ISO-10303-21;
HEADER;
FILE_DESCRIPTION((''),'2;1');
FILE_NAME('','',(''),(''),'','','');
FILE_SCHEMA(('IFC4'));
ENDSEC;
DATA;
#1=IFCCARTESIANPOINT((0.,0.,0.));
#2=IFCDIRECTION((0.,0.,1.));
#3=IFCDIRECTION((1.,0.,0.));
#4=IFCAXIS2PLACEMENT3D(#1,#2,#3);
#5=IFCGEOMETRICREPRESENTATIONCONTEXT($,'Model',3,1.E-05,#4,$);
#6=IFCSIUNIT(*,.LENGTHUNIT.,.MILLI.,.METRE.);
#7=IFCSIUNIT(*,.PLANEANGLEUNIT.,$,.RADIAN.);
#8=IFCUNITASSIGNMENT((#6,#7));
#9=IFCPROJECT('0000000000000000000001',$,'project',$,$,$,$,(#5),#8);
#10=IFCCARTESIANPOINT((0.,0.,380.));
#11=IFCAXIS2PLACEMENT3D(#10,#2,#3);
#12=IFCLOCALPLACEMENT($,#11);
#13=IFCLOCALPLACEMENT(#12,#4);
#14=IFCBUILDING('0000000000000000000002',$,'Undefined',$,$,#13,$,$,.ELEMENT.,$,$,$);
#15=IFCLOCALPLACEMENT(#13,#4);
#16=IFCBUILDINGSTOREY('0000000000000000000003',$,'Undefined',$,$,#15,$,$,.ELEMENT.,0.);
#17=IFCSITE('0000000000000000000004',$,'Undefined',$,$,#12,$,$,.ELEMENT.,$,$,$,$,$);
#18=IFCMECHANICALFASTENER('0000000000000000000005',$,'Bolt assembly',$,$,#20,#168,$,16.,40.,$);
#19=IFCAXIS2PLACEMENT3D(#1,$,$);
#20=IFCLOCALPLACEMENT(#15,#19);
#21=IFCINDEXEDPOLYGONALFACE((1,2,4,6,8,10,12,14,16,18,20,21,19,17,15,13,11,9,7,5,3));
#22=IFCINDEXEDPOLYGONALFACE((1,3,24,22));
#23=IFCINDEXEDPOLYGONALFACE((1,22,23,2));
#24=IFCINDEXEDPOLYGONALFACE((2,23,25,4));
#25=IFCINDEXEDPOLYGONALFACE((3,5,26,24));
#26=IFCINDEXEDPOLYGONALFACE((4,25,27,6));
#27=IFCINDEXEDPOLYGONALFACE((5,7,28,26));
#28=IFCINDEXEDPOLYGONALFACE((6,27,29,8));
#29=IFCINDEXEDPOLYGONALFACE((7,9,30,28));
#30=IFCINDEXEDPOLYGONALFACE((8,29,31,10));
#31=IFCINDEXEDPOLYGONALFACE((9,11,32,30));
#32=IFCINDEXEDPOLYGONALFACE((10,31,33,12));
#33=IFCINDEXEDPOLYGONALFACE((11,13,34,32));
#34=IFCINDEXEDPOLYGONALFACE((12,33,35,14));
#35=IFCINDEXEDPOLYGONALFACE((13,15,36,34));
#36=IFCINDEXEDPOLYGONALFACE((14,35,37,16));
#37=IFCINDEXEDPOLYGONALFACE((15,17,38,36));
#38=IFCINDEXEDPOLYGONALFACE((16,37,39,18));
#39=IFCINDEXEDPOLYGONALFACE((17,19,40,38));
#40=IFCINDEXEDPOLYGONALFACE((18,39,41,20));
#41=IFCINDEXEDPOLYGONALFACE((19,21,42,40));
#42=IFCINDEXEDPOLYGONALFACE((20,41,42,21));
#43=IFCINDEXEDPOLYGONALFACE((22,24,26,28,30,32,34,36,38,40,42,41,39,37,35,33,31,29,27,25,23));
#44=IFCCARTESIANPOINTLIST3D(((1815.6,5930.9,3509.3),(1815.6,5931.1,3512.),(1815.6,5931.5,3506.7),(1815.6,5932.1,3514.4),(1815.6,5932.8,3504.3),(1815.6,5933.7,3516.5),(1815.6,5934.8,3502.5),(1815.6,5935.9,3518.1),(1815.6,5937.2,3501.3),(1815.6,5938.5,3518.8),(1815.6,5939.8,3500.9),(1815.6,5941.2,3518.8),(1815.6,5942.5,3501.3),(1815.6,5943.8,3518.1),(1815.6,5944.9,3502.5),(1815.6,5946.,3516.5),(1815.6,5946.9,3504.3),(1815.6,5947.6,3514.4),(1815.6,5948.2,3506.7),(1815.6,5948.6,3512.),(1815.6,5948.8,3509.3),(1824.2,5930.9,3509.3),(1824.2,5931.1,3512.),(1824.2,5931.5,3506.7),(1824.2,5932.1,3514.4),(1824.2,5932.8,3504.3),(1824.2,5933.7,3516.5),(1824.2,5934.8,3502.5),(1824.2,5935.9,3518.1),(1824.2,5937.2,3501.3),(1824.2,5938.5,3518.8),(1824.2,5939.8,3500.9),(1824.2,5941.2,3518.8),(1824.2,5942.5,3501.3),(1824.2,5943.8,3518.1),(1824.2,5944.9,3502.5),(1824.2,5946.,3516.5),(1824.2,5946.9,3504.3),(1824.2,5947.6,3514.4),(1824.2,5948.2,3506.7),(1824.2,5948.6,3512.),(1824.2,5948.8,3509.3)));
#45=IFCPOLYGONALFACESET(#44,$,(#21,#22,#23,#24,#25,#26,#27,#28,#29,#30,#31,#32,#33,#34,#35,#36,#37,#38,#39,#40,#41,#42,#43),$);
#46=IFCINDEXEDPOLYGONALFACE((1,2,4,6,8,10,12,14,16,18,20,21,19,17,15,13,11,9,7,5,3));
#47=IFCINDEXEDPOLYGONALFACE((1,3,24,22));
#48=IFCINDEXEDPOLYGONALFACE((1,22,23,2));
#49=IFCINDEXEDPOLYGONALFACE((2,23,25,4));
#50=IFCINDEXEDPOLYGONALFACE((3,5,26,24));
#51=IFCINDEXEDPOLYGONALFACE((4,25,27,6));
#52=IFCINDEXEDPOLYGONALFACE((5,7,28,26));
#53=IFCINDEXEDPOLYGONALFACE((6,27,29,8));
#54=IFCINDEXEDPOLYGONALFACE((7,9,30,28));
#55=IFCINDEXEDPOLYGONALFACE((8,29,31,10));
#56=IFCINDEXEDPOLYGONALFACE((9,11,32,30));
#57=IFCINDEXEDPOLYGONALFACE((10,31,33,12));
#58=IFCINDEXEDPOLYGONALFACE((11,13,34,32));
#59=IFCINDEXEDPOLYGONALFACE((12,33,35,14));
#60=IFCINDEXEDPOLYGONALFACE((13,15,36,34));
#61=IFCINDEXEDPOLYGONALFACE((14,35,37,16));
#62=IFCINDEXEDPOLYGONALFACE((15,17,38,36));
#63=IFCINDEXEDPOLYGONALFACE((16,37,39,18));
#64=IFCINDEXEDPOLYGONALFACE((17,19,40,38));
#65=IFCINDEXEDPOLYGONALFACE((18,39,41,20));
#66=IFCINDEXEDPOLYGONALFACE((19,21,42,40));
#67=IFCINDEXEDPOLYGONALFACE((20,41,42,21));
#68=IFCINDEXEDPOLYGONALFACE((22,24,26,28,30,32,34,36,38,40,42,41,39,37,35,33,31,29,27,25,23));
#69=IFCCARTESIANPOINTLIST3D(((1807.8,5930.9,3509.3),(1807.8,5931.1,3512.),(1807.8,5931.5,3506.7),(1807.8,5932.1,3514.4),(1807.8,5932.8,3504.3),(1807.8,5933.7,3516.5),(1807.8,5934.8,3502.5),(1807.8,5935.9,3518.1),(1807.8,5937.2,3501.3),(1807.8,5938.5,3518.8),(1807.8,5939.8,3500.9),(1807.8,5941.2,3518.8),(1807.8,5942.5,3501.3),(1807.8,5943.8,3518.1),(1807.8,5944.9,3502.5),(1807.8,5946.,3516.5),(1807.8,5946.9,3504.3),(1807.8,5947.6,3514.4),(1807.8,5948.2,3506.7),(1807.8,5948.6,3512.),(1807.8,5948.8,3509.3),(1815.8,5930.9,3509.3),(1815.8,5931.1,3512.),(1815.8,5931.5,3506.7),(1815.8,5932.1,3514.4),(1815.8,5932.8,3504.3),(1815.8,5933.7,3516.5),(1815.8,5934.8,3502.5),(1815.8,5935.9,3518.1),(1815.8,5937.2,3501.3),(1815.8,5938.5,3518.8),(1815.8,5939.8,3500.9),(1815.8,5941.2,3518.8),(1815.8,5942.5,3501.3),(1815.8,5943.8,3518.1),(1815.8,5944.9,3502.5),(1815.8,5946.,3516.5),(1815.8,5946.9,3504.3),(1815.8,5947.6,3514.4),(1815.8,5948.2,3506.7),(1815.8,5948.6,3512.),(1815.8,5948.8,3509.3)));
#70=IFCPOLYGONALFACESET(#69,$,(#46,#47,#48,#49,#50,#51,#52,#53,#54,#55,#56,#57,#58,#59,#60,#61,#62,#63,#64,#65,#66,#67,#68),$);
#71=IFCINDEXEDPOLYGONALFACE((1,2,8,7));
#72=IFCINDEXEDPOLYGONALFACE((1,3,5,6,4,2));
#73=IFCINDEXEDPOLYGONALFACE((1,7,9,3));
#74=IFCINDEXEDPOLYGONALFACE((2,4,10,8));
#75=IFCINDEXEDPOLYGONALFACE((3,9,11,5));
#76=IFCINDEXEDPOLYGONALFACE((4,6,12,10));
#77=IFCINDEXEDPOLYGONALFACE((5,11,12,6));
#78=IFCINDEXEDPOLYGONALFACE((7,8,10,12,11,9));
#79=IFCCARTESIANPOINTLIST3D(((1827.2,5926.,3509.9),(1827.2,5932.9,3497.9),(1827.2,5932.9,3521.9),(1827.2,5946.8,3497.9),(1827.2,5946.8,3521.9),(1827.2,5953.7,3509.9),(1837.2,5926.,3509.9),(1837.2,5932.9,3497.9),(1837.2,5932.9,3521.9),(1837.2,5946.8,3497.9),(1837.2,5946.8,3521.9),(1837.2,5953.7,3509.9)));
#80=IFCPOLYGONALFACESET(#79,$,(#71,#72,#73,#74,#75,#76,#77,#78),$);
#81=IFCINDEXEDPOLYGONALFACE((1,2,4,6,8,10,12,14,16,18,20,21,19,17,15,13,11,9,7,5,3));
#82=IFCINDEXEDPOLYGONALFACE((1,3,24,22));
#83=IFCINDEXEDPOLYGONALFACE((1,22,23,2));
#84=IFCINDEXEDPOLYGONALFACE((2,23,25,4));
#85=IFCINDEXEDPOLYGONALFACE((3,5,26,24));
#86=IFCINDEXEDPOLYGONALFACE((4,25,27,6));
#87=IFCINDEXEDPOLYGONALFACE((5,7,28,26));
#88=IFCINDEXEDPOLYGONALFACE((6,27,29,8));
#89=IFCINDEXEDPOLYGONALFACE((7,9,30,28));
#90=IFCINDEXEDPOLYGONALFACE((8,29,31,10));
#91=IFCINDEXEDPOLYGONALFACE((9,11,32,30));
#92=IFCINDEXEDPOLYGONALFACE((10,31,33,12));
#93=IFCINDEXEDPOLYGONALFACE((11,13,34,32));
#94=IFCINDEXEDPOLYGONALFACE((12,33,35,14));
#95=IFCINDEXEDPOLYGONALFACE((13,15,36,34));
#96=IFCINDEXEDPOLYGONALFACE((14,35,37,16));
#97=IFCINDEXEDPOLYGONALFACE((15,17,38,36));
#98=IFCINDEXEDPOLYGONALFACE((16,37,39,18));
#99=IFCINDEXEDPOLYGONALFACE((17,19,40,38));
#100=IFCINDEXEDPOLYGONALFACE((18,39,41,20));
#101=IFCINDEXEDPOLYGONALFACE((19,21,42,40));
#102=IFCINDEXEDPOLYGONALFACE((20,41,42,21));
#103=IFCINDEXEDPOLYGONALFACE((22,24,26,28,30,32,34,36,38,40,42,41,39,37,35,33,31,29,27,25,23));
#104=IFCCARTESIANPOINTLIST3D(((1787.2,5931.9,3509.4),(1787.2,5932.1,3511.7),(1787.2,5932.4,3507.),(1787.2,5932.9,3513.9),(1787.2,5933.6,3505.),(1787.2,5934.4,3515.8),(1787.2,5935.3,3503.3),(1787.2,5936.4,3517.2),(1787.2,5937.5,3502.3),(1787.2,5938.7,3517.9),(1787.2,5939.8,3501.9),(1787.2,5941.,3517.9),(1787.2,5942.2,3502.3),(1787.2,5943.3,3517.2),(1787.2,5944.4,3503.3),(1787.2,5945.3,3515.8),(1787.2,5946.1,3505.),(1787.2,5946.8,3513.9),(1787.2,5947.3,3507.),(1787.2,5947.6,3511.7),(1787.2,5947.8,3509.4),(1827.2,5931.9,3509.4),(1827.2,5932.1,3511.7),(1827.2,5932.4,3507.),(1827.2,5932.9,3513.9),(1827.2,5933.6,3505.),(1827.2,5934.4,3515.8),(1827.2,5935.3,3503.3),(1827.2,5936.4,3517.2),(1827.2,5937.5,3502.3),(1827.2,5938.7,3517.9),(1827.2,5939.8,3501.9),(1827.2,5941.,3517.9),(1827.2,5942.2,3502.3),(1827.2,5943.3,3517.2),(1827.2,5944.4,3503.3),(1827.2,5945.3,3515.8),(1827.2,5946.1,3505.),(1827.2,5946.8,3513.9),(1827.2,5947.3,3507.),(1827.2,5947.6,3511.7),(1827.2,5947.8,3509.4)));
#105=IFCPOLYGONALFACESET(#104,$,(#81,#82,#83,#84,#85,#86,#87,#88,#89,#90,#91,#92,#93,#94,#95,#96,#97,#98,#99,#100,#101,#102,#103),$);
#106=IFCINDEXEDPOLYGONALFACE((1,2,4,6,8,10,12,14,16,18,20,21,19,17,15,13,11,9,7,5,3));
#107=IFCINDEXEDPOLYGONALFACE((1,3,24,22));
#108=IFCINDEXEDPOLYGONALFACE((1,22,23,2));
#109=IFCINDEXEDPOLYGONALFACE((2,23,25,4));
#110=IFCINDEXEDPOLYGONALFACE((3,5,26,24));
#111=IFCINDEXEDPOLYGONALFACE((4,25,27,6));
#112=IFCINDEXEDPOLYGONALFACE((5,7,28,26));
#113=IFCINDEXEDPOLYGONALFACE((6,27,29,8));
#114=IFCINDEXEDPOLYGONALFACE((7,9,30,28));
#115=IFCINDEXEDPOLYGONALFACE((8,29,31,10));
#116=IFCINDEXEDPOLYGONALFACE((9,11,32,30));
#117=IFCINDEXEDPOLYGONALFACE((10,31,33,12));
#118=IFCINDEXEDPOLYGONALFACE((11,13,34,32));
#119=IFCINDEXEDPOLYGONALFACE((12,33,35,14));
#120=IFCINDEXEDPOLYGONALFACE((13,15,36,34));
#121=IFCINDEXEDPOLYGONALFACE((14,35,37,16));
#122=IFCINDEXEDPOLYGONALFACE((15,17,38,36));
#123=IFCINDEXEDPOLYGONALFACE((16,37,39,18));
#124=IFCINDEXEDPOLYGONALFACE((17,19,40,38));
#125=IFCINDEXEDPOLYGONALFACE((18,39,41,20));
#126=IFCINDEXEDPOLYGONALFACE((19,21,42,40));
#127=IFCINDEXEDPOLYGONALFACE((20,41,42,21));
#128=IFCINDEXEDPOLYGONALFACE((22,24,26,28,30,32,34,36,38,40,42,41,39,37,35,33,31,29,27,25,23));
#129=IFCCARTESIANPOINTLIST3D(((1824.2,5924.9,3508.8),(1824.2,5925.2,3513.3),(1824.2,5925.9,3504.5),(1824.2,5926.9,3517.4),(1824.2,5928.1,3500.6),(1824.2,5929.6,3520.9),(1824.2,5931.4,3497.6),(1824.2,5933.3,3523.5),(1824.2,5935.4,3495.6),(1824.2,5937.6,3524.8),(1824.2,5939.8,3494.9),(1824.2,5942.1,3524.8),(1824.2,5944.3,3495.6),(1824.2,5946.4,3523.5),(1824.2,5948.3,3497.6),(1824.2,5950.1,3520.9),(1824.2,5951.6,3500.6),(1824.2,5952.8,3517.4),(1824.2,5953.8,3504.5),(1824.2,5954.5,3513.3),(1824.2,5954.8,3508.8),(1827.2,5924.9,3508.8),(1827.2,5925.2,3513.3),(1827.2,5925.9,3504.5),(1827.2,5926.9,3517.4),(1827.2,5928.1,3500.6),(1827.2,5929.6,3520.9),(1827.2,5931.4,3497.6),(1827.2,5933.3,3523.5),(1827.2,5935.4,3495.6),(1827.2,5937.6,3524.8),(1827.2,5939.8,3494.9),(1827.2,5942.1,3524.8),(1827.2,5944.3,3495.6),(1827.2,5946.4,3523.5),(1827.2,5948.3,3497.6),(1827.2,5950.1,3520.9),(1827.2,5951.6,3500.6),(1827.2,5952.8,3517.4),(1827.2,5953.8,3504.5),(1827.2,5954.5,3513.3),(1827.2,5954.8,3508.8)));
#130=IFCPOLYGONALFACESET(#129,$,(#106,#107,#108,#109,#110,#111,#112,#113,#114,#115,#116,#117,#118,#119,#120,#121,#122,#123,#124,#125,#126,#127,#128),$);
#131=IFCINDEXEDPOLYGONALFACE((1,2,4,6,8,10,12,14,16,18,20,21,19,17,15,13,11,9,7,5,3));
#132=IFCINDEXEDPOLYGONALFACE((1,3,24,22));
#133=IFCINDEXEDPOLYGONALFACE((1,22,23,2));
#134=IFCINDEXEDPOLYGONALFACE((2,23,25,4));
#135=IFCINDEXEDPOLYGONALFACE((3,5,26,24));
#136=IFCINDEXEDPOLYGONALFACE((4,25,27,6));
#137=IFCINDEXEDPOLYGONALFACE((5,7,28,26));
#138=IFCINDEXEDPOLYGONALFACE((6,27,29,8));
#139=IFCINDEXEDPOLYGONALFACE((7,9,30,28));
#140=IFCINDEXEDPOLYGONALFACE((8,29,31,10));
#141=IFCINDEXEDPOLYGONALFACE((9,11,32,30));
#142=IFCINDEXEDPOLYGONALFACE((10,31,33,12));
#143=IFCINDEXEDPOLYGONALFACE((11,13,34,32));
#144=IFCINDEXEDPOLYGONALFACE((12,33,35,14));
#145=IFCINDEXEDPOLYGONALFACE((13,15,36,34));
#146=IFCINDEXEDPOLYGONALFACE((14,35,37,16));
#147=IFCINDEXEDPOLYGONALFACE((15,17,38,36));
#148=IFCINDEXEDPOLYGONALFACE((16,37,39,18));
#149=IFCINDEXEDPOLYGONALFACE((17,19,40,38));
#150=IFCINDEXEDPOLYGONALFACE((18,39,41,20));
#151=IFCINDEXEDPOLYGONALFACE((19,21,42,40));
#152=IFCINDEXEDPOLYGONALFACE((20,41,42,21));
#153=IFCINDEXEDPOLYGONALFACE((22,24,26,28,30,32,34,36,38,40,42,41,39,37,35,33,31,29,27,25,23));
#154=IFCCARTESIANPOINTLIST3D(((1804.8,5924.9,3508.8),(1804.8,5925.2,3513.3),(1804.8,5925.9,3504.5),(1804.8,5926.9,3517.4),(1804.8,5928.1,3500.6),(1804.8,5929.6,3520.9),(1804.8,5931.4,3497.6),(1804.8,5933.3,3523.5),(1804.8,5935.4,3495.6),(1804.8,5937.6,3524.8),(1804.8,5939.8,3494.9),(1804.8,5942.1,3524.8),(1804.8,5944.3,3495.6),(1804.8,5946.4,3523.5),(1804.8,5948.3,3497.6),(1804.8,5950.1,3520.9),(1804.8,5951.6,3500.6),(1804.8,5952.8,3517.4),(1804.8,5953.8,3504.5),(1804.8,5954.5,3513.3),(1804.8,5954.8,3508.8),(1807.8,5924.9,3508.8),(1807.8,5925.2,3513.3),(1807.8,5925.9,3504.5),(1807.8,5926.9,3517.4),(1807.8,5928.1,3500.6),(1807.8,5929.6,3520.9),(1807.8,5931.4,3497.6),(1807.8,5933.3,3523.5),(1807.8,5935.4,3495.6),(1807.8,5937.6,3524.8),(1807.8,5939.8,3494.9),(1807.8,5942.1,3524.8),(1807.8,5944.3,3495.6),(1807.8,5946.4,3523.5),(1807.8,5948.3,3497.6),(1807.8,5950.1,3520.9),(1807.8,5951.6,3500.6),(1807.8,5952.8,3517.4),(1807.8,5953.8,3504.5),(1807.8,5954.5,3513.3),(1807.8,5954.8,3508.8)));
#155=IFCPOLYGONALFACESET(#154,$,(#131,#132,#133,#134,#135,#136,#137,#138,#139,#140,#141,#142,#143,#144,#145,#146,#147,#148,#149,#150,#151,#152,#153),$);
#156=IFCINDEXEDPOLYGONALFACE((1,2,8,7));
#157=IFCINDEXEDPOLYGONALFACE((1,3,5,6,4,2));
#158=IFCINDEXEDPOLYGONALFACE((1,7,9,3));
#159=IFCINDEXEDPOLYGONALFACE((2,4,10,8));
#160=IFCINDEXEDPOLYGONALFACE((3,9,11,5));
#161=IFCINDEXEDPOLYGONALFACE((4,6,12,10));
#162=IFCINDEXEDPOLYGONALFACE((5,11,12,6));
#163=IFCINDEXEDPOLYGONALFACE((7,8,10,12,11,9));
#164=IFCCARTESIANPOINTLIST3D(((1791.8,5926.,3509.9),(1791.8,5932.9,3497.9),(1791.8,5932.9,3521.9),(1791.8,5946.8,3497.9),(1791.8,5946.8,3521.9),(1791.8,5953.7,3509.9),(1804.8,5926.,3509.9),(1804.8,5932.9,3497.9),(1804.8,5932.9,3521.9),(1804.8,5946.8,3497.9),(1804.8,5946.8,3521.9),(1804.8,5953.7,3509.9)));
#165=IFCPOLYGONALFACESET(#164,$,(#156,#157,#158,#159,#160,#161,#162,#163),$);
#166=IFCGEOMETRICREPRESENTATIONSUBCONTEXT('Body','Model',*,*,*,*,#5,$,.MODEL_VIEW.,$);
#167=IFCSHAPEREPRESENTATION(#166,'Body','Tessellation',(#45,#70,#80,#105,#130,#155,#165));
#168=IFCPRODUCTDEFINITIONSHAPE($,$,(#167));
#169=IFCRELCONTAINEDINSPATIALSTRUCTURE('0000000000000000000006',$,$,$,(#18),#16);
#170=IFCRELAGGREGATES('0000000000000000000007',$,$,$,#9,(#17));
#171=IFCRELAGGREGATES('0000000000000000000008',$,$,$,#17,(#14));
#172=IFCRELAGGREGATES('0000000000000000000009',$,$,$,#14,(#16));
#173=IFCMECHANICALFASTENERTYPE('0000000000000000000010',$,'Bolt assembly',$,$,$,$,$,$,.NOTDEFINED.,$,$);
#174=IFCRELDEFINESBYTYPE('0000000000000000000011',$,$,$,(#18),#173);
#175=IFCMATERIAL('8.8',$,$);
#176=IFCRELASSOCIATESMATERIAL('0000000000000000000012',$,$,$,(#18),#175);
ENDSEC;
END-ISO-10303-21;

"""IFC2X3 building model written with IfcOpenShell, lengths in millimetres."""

from ifc_helpers import new_model, si_unit, frame, origin_with_axes, origin_2d_with_axis, place, context, subcontext, project, spatial, polyline, circle, outline, extrude, source, transform, mapped, material, type_object, element, save


model = new_model("IFC2X3")

# Units and contexts
model_context = context("Model", 3, precision=1e-05, world=origin_with_axes())
body_context = subcontext(model_context, "Body", "Model", "MODEL_VIEW")
ifc_project = project(units=[si_unit("LENGTHUNIT", "METRE", prefix="MILLI"), si_unit("PLANEANGLEUNIT", "RADIAN")], contexts=[model_context])

# Site, building, storey
site_placement = place(None, frame((0.0, 0.0, 380.0), z_axis=(0.0, 0.0, 1.0), x_axis=(1.0, 0.0, 0.0)))
site = spatial("IfcSite", under=ifc_project, at=site_placement, Name="Undefined", CompositionType="ELEMENT")
building_placement = place(site_placement, origin_with_axes())
building = spatial("IfcBuilding", under=site, at=building_placement, Name="Undefined", CompositionType="ELEMENT")
storey_placement = place(building_placement, origin_with_axes())
storey = spatial("IfcBuildingStorey", under=building, at=storey_placement, Name="Undefined", CompositionType="ELEMENT", Elevation=0.0)

# Mechanical fastener
ifc_material_1 = material(Name="8.8")
mechanical_fastener_type = type_object("IfcMechanicalFastenerType", Name="Bolt assembly")
shared_shape_1 = source(origin_with_axes(), body_context, "Body", "SweptSolid", [
    extrude(circle(Radius=9.0, at=origin_2d_with_axis()), frame((0.0, -8.4, 0.0), z_axis=(0.0, 1.0, 0.0), x_axis=(1.0, 0.0, 0.0)), (0.0, 0.0, 1.0), 8.5),
    extrude(circle(Radius=9.0, at=origin_2d_with_axis()), frame((0.0, -0.1, 0.0), z_axis=(0.0, 1.0, 0.0), x_axis=(1.0, 0.0, 0.0)), (0.0, 0.0, 1.0), 8.1),
    extrude(outline(polyline([(12.0, -6.9), (12.0, 6.9), (0.0, 13.9), (-12.0, 6.9), (-12.0, -6.9), (0.0, -13.9), (12.0, -6.9)])), frame((0.0, -21.5, 0.0), z_axis=(0.0, 1.0, 0.0), x_axis=(1.0, 0.0, 0.0)), (0.0, 0.0, 1.0), 10.0),
    extrude(circle(Radius=8.0, at=origin_2d_with_axis()), frame((0.0, -11.5, 0.0), z_axis=(0.0, 1.0, 0.0), x_axis=(1.0, 0.0, 0.0)), (0.0, 0.0, 1.0), 40.0),
    extrude(circle(Radius=15.0, at=origin_2d_with_axis()), frame((0.0, -11.5, 0.0), z_axis=(0.0, 1.0, 0.0), x_axis=(1.0, 0.0, 0.0)), (0.0, 0.0, 1.0), 3.0),
    extrude(circle(Radius=15.0, at=origin_2d_with_axis()), frame((0.0, 8.0, 0.0), z_axis=(0.0, 1.0, 0.0), x_axis=(1.0, 0.0, 0.0)), (0.0, 0.0, 1.0), 3.0),
    extrude(outline(polyline([(12.0, -6.9), (12.0, 6.9), (0.0, 13.9), (-12.0, 6.9), (-12.0, -6.9), (0.0, -13.9), (12.0, -6.9)])), frame((0.0, 11.0, 0.0), z_axis=(0.0, 1.0, 0.0), x_axis=(1.0, 0.0, 0.0)), (0.0, 0.0, 1.0), 13.0),
])
mechanical_fastener_1_placement = place(storey_placement, frame((1815.8, 5902.3, 3579.9), z_axis=(0.0, 1.0, 0.0), x_axis=(0.0, 0.0, -1.0)))
element("IfcMechanicalFastener", 1, at=mechanical_fastener_1_placement, inside=storey, type_object=mechanical_fastener_type, material=ifc_material_1, Name="Bolt assembly", NominalDiameter=16.0, NominalLength=40.0, context=body_context, shape_type="MappedRepresentation", body=[
    mapped(shared_shape_1, transform((70.0, 0.0, 37.5))),
])

save(model, "model.ifc")
